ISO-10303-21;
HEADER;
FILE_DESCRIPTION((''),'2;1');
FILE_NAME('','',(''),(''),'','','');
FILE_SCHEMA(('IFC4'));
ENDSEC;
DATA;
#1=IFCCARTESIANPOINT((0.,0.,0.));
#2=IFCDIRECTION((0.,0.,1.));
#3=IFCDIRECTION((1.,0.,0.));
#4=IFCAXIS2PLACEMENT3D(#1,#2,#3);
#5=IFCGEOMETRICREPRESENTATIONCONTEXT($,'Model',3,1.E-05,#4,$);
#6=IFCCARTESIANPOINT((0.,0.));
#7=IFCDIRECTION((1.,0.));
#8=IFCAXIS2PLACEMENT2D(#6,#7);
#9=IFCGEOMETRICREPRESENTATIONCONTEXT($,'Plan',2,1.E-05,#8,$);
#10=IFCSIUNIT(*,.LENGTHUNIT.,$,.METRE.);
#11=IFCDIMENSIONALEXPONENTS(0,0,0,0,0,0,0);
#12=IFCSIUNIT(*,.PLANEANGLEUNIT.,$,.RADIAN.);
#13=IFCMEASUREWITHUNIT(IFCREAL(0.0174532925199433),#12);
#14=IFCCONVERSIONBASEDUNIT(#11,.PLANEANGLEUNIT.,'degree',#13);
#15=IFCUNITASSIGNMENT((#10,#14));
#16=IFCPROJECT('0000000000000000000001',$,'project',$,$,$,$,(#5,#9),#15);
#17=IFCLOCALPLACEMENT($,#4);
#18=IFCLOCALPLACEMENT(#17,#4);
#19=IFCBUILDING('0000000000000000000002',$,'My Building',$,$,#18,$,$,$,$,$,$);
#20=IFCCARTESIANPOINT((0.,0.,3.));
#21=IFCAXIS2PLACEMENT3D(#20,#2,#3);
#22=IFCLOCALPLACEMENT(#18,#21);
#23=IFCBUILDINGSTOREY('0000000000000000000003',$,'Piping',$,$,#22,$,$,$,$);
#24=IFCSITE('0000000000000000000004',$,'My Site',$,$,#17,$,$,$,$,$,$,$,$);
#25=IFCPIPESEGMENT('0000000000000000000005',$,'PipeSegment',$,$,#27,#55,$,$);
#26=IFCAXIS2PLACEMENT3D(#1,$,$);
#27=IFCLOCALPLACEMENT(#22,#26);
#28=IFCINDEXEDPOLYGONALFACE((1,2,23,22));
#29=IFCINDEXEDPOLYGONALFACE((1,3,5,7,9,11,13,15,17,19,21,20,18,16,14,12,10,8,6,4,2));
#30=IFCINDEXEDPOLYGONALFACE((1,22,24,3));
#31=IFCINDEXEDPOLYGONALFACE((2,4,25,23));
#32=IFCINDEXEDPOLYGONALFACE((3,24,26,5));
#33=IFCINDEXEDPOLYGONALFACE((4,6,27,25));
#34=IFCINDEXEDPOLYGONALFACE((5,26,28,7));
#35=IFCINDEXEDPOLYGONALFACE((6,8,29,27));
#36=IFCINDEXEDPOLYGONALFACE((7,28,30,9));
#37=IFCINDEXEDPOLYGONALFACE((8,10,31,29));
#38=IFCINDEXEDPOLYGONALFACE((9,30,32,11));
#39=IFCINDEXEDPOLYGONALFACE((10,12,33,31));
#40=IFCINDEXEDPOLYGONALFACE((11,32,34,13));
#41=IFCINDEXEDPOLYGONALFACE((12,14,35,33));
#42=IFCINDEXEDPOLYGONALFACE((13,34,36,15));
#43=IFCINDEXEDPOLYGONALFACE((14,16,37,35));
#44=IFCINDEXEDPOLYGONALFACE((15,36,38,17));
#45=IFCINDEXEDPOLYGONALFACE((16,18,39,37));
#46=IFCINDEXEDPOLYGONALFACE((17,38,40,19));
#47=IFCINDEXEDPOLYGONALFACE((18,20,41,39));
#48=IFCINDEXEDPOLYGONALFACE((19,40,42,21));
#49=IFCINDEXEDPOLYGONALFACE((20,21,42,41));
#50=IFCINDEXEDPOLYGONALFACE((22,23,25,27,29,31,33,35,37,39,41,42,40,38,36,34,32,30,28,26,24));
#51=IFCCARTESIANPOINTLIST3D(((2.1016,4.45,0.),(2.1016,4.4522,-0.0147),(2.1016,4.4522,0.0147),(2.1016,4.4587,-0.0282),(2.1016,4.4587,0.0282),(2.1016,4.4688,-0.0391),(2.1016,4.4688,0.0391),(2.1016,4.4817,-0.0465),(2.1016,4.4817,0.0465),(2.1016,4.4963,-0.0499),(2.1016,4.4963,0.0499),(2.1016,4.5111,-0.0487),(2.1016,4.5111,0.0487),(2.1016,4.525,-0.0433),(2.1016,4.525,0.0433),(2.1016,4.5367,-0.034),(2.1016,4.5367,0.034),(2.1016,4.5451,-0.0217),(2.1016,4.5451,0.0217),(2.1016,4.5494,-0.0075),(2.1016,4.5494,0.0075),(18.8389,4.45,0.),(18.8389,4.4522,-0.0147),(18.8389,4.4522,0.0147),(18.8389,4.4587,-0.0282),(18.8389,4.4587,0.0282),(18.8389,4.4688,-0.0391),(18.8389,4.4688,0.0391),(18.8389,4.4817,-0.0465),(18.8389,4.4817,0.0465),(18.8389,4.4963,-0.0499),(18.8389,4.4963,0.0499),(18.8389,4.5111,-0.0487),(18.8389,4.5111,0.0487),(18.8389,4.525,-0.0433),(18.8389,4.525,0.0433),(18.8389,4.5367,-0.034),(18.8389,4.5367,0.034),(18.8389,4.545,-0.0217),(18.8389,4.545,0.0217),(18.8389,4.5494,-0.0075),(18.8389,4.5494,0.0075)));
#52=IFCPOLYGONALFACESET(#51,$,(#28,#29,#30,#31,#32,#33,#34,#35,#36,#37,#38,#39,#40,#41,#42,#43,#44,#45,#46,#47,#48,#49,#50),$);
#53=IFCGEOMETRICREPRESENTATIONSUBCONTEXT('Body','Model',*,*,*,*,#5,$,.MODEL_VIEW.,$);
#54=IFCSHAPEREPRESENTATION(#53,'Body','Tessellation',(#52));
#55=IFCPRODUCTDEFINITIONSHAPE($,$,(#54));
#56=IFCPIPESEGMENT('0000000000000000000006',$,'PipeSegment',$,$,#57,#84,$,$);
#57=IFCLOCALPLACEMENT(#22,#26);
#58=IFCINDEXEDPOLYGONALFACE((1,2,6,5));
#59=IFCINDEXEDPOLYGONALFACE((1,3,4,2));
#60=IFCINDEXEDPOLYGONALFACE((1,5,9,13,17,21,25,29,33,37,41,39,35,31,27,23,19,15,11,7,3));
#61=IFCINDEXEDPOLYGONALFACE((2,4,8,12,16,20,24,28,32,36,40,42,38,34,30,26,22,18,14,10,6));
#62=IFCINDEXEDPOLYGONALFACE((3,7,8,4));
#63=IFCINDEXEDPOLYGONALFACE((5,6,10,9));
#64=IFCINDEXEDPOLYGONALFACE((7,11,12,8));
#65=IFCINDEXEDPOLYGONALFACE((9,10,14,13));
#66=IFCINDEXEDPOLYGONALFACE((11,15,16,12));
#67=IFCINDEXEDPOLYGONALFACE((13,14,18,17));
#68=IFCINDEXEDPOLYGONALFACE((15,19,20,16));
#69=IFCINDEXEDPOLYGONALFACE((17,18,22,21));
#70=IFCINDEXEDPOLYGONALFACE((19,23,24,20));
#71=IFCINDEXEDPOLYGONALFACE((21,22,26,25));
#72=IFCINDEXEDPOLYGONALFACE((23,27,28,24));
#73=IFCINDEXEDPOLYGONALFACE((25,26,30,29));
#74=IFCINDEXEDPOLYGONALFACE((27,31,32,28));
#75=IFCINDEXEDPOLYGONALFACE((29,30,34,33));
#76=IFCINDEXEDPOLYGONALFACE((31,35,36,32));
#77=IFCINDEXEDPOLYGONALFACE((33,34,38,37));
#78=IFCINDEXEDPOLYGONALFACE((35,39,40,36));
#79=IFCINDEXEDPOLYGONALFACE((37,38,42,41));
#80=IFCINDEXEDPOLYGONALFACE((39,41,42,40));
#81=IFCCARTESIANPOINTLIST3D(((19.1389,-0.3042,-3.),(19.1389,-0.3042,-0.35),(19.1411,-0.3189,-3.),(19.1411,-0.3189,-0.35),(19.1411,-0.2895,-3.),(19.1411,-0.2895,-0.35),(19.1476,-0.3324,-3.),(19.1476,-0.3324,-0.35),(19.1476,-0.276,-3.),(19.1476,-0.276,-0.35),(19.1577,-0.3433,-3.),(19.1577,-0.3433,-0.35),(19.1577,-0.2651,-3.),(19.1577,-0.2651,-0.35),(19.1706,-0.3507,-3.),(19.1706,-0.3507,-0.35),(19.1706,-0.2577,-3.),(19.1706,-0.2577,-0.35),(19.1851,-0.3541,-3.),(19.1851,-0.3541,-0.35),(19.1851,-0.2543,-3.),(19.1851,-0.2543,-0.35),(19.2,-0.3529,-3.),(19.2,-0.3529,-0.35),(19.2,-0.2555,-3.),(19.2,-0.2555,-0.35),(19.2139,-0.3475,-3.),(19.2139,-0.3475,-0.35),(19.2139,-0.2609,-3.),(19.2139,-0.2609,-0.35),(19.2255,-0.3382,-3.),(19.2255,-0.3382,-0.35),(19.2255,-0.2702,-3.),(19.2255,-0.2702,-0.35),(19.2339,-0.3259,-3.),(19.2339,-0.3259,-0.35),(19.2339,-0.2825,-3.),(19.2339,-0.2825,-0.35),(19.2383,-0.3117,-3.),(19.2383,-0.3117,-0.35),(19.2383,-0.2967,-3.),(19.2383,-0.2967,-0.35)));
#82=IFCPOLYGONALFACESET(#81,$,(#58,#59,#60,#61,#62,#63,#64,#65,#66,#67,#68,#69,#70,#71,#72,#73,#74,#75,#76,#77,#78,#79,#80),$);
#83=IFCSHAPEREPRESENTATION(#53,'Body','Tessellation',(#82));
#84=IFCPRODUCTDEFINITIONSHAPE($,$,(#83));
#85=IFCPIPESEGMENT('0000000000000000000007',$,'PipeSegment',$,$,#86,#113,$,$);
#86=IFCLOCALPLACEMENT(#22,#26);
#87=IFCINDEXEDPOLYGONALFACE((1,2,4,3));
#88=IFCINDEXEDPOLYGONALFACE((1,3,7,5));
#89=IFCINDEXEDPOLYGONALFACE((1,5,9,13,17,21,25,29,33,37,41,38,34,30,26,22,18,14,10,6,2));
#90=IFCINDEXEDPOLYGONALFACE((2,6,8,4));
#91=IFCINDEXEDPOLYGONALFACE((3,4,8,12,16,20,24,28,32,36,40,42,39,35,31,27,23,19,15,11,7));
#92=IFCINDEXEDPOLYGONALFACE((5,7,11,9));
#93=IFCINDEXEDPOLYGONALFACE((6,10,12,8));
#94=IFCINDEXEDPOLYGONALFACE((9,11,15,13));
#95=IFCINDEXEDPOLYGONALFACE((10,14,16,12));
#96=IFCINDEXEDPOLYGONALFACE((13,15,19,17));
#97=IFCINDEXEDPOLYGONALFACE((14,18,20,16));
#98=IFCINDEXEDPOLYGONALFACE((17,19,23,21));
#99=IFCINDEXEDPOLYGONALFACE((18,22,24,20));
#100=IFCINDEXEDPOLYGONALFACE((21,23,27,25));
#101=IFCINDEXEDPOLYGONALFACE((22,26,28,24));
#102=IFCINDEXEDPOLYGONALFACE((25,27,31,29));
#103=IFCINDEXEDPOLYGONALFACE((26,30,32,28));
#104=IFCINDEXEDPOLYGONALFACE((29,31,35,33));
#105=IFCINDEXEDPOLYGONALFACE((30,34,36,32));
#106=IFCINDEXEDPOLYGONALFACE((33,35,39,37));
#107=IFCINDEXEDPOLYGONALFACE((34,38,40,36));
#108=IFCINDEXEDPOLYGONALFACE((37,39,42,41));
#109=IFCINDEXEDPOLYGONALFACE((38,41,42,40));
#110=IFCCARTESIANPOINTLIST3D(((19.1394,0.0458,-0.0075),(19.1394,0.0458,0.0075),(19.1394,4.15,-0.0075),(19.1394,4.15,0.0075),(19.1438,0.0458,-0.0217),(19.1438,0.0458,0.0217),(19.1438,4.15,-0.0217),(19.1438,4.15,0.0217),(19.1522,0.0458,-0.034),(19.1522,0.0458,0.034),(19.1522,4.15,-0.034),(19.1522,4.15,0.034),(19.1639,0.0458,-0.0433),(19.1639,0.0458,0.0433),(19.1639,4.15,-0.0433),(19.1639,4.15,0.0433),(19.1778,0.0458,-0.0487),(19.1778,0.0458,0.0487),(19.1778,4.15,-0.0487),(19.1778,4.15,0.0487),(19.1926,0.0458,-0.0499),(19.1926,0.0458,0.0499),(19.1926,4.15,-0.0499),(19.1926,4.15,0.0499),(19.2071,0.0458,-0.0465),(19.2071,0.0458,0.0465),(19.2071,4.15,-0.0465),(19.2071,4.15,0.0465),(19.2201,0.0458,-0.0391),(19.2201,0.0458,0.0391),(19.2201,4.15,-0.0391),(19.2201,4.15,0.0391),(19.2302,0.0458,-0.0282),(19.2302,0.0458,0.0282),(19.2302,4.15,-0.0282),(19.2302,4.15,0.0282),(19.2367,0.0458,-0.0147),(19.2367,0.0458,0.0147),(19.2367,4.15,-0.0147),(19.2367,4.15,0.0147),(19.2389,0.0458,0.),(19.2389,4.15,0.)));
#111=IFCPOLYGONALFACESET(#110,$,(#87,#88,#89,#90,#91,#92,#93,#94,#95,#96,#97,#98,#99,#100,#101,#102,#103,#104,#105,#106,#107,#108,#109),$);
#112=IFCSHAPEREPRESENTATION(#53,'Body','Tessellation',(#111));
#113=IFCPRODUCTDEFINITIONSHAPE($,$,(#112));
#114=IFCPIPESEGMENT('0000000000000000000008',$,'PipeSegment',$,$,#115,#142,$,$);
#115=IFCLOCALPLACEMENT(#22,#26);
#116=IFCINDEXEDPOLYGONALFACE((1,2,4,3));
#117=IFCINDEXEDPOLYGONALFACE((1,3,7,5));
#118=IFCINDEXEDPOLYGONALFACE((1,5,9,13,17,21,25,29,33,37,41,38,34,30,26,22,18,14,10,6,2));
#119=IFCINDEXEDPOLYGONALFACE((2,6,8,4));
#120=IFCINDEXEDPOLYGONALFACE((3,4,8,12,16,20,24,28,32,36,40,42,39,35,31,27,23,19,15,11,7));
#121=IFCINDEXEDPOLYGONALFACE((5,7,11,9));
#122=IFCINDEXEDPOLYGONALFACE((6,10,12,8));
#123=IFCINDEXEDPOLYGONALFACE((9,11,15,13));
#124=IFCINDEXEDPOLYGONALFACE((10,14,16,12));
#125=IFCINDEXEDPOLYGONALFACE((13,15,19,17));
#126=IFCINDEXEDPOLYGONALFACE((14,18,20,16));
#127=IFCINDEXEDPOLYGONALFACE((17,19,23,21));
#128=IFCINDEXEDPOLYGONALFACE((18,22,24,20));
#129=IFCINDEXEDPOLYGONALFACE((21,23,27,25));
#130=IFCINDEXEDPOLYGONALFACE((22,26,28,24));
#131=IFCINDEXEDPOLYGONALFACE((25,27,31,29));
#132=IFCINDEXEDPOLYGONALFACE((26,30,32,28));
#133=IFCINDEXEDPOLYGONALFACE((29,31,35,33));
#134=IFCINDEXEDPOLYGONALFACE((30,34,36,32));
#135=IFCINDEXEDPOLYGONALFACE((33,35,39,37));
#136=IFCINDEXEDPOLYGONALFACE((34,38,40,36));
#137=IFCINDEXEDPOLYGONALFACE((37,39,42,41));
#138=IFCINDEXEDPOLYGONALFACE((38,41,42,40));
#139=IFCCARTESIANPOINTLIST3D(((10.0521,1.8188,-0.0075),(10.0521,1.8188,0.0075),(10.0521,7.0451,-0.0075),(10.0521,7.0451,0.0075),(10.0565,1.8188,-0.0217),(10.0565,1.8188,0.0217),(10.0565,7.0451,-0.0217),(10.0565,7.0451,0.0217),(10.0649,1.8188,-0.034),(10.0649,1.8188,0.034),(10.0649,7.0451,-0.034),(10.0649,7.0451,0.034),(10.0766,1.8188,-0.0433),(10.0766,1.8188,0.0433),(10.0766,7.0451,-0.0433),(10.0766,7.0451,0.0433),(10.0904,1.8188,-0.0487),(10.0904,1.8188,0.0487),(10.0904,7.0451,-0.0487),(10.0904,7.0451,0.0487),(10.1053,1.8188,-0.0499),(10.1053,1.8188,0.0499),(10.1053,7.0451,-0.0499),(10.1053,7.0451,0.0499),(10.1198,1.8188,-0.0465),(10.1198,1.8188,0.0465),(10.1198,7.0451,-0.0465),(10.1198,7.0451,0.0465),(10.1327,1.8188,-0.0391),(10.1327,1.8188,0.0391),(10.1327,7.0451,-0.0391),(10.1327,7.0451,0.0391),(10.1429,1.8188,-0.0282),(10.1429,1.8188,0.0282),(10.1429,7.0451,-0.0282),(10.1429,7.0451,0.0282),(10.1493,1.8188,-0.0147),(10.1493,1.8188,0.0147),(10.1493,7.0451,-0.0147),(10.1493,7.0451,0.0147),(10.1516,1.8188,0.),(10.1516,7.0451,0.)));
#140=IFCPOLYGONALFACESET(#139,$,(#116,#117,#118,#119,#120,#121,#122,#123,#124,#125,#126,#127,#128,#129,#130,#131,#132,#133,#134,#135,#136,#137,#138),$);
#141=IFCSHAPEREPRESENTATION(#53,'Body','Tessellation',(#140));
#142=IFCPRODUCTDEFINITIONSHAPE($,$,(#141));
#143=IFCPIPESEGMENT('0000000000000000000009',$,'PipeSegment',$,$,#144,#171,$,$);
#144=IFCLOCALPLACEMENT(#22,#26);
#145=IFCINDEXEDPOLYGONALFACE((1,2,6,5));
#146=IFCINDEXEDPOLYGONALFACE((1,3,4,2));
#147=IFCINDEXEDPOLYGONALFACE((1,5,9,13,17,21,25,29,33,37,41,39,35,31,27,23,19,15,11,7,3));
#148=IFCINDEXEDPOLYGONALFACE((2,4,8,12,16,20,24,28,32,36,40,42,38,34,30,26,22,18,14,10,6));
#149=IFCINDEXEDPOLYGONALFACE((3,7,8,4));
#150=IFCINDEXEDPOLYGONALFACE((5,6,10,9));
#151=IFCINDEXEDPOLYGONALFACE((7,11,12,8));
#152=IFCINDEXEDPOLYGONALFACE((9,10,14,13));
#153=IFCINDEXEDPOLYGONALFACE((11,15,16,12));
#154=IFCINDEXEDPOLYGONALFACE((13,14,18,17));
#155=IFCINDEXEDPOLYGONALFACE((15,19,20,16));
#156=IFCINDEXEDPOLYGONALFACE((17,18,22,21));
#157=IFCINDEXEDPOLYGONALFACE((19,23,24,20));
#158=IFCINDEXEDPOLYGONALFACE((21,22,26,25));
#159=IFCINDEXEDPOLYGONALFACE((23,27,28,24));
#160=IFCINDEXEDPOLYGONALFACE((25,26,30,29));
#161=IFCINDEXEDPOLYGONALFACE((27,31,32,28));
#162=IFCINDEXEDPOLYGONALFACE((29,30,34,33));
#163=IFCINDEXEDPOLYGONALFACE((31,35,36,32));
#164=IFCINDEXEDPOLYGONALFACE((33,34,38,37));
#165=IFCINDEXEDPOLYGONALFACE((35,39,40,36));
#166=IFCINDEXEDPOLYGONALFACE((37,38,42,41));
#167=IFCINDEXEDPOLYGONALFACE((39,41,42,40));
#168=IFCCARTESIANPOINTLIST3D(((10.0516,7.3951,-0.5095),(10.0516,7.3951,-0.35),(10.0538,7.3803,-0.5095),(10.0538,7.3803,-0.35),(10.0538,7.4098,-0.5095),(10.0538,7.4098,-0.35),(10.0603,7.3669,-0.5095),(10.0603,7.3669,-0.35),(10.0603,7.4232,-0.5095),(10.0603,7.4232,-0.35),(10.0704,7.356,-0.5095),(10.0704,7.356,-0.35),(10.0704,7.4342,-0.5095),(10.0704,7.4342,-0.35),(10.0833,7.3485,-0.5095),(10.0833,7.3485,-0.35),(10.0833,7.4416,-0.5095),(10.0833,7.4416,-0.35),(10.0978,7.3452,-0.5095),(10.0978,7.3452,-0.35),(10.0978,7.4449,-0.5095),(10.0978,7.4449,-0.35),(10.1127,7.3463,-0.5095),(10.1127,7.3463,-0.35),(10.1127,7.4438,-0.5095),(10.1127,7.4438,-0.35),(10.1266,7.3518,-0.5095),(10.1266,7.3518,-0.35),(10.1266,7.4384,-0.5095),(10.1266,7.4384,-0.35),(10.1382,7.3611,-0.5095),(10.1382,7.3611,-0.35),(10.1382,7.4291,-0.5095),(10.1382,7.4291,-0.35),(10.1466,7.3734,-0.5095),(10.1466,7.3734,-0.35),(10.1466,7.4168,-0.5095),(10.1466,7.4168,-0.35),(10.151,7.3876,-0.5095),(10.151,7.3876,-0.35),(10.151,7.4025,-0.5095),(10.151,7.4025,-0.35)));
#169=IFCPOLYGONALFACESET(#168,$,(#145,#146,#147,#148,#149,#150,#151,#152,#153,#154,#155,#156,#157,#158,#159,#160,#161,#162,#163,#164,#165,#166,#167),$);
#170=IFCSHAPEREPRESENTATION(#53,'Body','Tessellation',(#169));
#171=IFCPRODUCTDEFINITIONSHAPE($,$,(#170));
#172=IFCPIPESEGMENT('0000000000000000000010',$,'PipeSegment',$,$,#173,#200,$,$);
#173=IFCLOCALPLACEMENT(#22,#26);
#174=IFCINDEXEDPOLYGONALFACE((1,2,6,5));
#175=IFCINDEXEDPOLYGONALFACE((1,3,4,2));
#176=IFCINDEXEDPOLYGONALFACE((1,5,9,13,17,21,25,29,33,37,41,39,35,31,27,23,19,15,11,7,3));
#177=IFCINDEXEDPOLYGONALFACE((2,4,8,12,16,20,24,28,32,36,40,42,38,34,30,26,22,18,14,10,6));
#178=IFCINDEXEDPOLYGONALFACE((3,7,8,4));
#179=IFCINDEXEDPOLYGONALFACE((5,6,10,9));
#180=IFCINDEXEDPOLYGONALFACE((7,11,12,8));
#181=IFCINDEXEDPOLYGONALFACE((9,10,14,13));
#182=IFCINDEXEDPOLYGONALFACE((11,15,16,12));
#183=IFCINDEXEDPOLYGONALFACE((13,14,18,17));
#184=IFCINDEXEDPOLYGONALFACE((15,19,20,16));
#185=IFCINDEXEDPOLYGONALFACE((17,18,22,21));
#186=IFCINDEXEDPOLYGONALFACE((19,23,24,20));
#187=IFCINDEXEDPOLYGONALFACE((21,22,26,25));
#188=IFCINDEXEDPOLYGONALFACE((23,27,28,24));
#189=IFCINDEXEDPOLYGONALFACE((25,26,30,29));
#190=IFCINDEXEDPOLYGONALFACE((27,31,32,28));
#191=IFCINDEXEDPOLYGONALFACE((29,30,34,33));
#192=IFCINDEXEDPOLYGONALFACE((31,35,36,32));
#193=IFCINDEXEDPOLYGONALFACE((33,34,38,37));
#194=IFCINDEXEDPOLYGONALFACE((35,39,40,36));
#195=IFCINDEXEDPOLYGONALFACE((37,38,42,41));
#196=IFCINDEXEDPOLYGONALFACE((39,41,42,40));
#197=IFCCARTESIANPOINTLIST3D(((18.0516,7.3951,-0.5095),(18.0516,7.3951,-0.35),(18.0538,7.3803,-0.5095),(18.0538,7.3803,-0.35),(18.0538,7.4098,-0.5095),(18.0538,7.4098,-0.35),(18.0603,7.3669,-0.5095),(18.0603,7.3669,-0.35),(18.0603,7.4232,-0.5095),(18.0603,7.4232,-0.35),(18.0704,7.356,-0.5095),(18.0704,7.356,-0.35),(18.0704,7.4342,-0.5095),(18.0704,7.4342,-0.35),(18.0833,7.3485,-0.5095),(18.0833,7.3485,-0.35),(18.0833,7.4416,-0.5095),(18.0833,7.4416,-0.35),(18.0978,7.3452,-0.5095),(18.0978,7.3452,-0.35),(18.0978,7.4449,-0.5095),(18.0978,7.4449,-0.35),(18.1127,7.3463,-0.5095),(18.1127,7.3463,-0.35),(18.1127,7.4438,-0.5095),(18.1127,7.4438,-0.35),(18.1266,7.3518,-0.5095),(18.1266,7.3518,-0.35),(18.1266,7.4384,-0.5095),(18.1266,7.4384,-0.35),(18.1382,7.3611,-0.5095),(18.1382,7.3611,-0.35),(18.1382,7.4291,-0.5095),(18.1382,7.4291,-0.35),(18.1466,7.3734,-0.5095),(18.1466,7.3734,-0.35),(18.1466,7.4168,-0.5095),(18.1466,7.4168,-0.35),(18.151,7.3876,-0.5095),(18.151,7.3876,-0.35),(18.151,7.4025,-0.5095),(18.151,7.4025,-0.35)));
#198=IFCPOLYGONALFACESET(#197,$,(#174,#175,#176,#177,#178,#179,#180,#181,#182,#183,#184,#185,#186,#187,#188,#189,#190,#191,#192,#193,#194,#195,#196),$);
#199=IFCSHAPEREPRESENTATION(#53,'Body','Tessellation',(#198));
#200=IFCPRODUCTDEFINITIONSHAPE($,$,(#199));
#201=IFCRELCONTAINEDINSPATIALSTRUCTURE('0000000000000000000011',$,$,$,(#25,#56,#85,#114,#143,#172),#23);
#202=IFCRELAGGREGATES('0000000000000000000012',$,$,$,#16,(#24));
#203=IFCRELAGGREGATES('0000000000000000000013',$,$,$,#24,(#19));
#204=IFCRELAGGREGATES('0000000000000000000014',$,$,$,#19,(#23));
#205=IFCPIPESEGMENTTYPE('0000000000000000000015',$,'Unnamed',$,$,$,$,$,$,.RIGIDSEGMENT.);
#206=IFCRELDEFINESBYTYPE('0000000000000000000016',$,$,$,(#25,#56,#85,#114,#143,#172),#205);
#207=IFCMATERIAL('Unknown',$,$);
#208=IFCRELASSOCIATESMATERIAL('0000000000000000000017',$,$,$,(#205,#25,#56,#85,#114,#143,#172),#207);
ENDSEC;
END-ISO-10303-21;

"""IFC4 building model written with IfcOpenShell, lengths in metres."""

from ifc_helpers import new_model, entity, si_unit, converted_unit, frame, origin_with_axes, origin_2d_with_axis, place, context, subcontext, project, spatial, circle, extrude, material, material_profile, profile_set, profile_usage, type_object, element, save


model = new_model("IFC4")

# Units and contexts
model_context = context("Model", 3, precision=1e-05, world=origin_with_axes())
plan_context = context("Plan", 2, precision=1e-05, world=origin_2d_with_axis())
body_context = subcontext(model_context, "Body", "Model", "MODEL_VIEW")
ifc_project = project(units=[si_unit("LENGTHUNIT", "METRE"), converted_unit("PLANEANGLEUNIT", "degree", entity("IfcReal", 0.0174532925199433), si_unit("PLANEANGLEUNIT", "RADIAN"), dimensions=[0, 0, 0, 0, 0, 0, 0])], contexts=[model_context, plan_context])

# Site, building, storey
site_placement = place(None, origin_with_axes())
site = spatial("IfcSite", under=ifc_project, at=site_placement, Name="My Site")
building_placement = place(site_placement, origin_with_axes())
building = spatial("IfcBuilding", under=site, at=building_placement, Name="My Building")
storey_placement = place(building_placement, frame((0.0, 0.0, 3.0), z_axis=(0.0, 0.0, 1.0), x_axis=(1.0, 0.0, 0.0)))
storey = spatial("IfcBuildingStorey", under=building, at=storey_placement, Name="Piping")

# Pipe segments
ifc_material = material(Name="Unknown")
ifc_material_profile = material_profile(ifc_material, circle(Radius=0.05))
ifc_profile_set = profile_set([ifc_material_profile])
ifc_profile_usage_1 = profile_usage(ifc_profile_set, cardinal=5)
pipe_segment_type = type_object("IfcPipeSegmentType", Name="Unnamed", PredefinedType="RIGIDSEGMENT", material=ifc_profile_set)
pipe_segment_1_placement = place(storey_placement, frame((18.8389, 4.5, 0.0), z_axis=(-1.0, 0.0, 0.0), x_axis=(0.0, -1.0, 0.0)))
element("IfcPipeSegment", 1, at=pipe_segment_1_placement, inside=storey, type_object=pipe_segment_type, material=ifc_profile_usage_1, Name="PipeSegment", context=body_context, shape_type="SweptSolid", body=[
    extrude(circle(Radius=0.05), origin_with_axes(), (0.0, 0.0, 1.0), 16.7373),
])
ifc_profile_usage_2 = profile_usage(ifc_profile_set, cardinal=5)
pipe_segment_2_placement = place(storey_placement, frame((19.1889, -0.3042, -0.35), z_axis=(0.0, 0.0, -1.0), x_axis=(-1.0, 0.0, 0.0)))
element("IfcPipeSegment", 2, at=pipe_segment_2_placement, inside=storey, type_object=pipe_segment_type, material=ifc_profile_usage_2, Name="PipeSegment", context=body_context, shape_type="SweptSolid", body=[
    extrude(circle(Radius=0.05), origin_with_axes(), (0.0, 0.0, 1.0), 2.65),
])
ifc_profile_usage_3 = profile_usage(ifc_profile_set, cardinal=5)
pipe_segment_3_placement = place(storey_placement, frame((19.1889, 0.0458, 0.0), z_axis=(0.0, 1.0, 0.0), x_axis=(1.0, 0.0, 0.0)))
element("IfcPipeSegment", 3, at=pipe_segment_3_placement, inside=storey, type_object=pipe_segment_type, material=ifc_profile_usage_3, Name="PipeSegment", context=body_context, shape_type="SweptSolid", body=[
    extrude(circle(Radius=0.05), origin_with_axes(), (0.0, 0.0, 1.0), 4.1042),
])
ifc_profile_usage_4 = profile_usage(ifc_profile_set, cardinal=5)
pipe_segment_4_placement = place(storey_placement, frame((10.1016, 1.8188, 0.0), z_axis=(0.0, 1.0, 0.0), x_axis=(1.0, 0.0, 0.0)))
element("IfcPipeSegment", 4, at=pipe_segment_4_placement, inside=storey, type_object=pipe_segment_type, material=ifc_profile_usage_4, Name="PipeSegment", context=body_context, shape_type="SweptSolid", body=[
    extrude(circle(Radius=0.05), origin_with_axes(), (0.0, 0.0, 1.0), 5.2262),
])
ifc_profile_usage_5 = profile_usage(ifc_profile_set, cardinal=5)
pipe_segment_5_placement = place(storey_placement, frame((10.1016, 7.3951, -0.35), z_axis=(0.0, 0.0, -1.0), x_axis=(-1.0, 0.0, 0.0)))
element("IfcPipeSegment", 5, at=pipe_segment_5_placement, inside=storey, type_object=pipe_segment_type, material=ifc_profile_usage_5, Name="PipeSegment", context=body_context, shape_type="SweptSolid", body=[
    extrude(circle(Radius=0.05), origin_with_axes(), (0.0, 0.0, 1.0), 0.1595),
])
ifc_profile_usage_6 = profile_usage(ifc_profile_set, cardinal=5)
pipe_segment_6_placement = place(storey_placement, frame((18.1016, 7.3951, -0.35), z_axis=(0.0, 0.0, -1.0), x_axis=(-1.0, 0.0, 0.0)))
element("IfcPipeSegment", 6, at=pipe_segment_6_placement, inside=storey, type_object=pipe_segment_type, material=ifc_profile_usage_6, Name="PipeSegment", context=body_context, shape_type="SweptSolid", body=[
    extrude(circle(Radius=0.05), origin_with_axes(), (0.0, 0.0, 1.0), 0.1595),
])

save(model, "model.ifc")
